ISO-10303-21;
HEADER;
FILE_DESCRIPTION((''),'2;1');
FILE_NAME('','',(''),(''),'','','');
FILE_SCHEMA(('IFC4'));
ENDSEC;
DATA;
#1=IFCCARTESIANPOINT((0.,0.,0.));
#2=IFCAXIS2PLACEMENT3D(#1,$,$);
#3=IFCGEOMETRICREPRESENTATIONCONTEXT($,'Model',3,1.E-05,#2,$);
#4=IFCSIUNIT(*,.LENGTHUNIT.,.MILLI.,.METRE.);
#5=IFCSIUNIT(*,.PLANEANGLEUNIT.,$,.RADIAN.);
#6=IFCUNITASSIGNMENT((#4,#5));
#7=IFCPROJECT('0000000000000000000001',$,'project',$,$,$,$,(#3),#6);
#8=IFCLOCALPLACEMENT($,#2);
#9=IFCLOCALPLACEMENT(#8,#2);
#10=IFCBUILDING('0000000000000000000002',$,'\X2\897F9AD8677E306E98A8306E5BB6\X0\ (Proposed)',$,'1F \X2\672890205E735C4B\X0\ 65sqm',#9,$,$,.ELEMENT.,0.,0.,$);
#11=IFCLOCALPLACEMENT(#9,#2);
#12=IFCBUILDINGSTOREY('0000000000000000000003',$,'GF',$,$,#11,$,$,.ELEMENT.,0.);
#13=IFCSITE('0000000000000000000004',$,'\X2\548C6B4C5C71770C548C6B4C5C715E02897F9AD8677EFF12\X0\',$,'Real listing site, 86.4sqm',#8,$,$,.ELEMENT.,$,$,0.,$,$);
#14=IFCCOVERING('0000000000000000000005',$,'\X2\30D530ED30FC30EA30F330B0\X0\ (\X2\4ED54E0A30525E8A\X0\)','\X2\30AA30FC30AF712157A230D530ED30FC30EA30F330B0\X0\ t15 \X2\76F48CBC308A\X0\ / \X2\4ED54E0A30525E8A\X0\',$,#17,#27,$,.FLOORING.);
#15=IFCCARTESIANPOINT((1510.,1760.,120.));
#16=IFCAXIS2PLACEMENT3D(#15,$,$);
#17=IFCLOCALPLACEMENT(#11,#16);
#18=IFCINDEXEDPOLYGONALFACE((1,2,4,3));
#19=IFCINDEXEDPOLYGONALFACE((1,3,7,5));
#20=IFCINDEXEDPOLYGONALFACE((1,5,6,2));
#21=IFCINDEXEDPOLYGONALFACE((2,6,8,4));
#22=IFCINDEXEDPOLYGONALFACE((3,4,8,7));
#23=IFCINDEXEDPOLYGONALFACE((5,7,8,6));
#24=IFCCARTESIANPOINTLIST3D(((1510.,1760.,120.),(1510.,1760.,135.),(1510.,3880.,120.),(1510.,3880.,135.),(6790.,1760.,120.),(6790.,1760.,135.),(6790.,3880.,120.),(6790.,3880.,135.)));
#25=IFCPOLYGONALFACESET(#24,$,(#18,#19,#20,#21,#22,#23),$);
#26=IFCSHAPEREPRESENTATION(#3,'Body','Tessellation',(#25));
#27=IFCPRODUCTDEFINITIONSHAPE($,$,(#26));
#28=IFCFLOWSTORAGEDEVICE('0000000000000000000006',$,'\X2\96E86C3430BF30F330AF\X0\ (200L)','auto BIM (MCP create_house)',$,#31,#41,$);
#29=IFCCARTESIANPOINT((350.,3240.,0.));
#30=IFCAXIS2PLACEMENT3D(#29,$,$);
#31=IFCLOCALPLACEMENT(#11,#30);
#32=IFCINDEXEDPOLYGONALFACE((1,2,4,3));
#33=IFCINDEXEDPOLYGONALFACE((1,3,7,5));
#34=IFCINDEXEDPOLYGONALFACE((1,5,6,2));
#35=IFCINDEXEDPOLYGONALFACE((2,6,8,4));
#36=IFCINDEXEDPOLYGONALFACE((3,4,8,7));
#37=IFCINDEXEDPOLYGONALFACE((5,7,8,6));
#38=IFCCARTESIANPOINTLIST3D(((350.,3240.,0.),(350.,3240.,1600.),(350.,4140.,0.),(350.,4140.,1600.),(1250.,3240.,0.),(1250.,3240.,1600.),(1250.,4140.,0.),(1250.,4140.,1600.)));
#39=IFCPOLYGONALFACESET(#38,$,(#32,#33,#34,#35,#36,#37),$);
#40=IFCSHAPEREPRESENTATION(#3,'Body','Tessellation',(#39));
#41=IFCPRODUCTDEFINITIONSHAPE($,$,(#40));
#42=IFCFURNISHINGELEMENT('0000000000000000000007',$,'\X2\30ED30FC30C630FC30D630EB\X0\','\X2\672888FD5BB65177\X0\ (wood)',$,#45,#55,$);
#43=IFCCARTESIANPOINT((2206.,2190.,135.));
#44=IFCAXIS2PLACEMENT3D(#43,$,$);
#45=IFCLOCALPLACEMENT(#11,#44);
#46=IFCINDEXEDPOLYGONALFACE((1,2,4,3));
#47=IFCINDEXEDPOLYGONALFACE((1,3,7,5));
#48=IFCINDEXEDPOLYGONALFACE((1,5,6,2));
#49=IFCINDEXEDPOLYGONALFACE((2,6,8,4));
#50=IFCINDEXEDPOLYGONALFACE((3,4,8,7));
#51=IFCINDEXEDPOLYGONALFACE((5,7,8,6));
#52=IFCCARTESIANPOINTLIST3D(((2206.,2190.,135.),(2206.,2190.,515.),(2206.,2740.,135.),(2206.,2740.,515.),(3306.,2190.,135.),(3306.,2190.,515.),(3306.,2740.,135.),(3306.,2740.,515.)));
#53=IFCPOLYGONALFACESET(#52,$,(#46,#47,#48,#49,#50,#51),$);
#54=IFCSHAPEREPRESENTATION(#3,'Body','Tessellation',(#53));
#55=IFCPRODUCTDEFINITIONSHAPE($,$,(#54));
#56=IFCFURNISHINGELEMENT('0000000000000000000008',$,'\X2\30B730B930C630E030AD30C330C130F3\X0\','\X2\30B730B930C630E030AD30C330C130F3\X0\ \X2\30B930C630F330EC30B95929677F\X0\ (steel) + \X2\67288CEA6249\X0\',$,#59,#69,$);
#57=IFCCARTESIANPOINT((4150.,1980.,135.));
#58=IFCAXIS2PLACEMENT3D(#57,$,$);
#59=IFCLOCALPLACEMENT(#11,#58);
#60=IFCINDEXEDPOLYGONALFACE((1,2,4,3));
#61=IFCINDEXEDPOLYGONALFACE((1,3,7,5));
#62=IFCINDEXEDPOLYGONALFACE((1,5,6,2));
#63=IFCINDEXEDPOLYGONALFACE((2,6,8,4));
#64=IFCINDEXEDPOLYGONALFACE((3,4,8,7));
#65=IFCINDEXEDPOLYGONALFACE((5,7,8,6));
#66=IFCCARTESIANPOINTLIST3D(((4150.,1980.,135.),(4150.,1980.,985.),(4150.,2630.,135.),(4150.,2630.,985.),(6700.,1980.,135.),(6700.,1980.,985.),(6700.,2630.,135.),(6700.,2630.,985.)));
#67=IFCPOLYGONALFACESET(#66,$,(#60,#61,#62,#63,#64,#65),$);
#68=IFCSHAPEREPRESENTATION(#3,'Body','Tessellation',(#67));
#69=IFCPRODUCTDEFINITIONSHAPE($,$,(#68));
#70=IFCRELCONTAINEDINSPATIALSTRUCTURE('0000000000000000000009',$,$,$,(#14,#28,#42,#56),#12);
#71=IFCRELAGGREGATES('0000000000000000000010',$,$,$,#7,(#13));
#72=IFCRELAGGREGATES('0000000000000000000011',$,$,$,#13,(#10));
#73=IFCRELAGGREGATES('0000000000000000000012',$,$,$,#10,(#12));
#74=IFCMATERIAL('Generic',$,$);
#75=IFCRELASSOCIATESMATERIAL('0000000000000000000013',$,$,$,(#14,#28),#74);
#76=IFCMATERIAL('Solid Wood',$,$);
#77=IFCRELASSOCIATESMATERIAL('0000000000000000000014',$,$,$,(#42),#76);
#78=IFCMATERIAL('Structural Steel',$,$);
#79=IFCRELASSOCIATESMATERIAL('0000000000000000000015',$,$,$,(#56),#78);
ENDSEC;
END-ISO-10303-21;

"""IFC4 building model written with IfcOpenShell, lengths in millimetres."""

from ifc_helpers import new_model, si_unit, frame, frame_2d, origin, place, context, project, spatial, rectangle, extrude, material, element, save


model = new_model("IFC4")

# Units and contexts
model_context = context("Model", 3, precision=1e-05, world=origin())
ifc_project = project(units=[si_unit("LENGTHUNIT", "METRE", prefix="MILLI"), si_unit("PLANEANGLEUNIT", "RADIAN")], contexts=[model_context])

# Site, building, storey
site_placement = place(None, origin())
site = spatial("IfcSite", under=ifc_project, at=site_placement, Name="和歌山県和歌山市西高松２", ObjectType="Real listing site, 86.4sqm", CompositionType="ELEMENT", RefElevation=0.0)
building_placement = place(site_placement, origin())
building = spatial("IfcBuilding", under=site, at=building_placement, Name="西高松の風の家 (Proposed)", ObjectType="1F 木造平屋 65sqm", CompositionType="ELEMENT", ElevationOfRefHeight=0.0, ElevationOfTerrain=0.0)
storey_placement = place(building_placement, origin())
storey = spatial("IfcBuildingStorey", under=building, at=storey_placement, Name="GF", CompositionType="ELEMENT", Elevation=0.0)

# Shared definitions
ifc_material_1 = material(Name="Solid Wood")

# Covering
ifc_material_2 = material(Name="Generic")
covering_placement = place(storey_placement, frame((1510.0, 1760.0, 120.0)))
element("IfcCovering", 1, at=covering_placement, inside=storey, material=ifc_material_2, Name="フローリング (仕上げ床)", Description="オーク無垢フローリング t15 直貼り / 仕上げ床", PredefinedType="FLOORING", context=model_context, shape_type="SweptSolid", body=[
    extrude(rectangle(XDim=5280.0, YDim=2120.0, at=frame_2d((2640.0, 1060.0))), frame((1510.0, 1760.0, 120.0)), (0.0, 0.0, 1.0), 15.0),
])

# Flow storage device
flow_storage_device_placement = place(storey_placement, frame((350.0, 3240.0, 0.0)))
element("IfcFlowStorageDevice", 2, at=flow_storage_device_placement, inside=storey, material=ifc_material_2, Name="雨水タンク (200L)", Description="auto BIM (MCP create_house)", context=model_context, shape_type="SweptSolid", body=[
    extrude(rectangle(XDim=900.0, YDim=900.0, at=frame_2d((450.0, 450.0))), frame((350.0, 3240.0, 0.0)), (0.0, 0.0, 1.0), 1600.0),
])

# Furnishing elements
furnishing_1_placement = place(storey_placement, frame((2206.0, 2190.0, 135.0)))
element("IfcFurnishingElement", 3, at=furnishing_1_placement, inside=storey, material=ifc_material_1, Name="ローテーブル", Description="木製家具 (wood)", context=model_context, shape_type="SweptSolid", body=[
    extrude(rectangle(XDim=1100.0, YDim=550.0, at=frame_2d((550.0, 275.0))), frame((2206.0, 2190.0, 135.0)), (0.0, 0.0, 1.0), 380.0),
])
ifc_material_3 = material(Name="Structural Steel")
furnishing_2_placement = place(storey_placement, frame((4150.0, 1980.0, 135.0)))
element("IfcFurnishingElement", 4, at=furnishing_2_placement, inside=storey, material=ifc_material_3, Name="システムキッチン", Description="システムキッチン ステンレス天板 (steel) + 木質扉", context=model_context, shape_type="SweptSolid", body=[
    extrude(rectangle(XDim=2550.0, YDim=650.0, at=frame_2d((1275.0, 325.0))), frame((4150.0, 1980.0, 135.0)), (0.0, 0.0, 1.0), 850.0),
])

save(model, "model.ifc")
